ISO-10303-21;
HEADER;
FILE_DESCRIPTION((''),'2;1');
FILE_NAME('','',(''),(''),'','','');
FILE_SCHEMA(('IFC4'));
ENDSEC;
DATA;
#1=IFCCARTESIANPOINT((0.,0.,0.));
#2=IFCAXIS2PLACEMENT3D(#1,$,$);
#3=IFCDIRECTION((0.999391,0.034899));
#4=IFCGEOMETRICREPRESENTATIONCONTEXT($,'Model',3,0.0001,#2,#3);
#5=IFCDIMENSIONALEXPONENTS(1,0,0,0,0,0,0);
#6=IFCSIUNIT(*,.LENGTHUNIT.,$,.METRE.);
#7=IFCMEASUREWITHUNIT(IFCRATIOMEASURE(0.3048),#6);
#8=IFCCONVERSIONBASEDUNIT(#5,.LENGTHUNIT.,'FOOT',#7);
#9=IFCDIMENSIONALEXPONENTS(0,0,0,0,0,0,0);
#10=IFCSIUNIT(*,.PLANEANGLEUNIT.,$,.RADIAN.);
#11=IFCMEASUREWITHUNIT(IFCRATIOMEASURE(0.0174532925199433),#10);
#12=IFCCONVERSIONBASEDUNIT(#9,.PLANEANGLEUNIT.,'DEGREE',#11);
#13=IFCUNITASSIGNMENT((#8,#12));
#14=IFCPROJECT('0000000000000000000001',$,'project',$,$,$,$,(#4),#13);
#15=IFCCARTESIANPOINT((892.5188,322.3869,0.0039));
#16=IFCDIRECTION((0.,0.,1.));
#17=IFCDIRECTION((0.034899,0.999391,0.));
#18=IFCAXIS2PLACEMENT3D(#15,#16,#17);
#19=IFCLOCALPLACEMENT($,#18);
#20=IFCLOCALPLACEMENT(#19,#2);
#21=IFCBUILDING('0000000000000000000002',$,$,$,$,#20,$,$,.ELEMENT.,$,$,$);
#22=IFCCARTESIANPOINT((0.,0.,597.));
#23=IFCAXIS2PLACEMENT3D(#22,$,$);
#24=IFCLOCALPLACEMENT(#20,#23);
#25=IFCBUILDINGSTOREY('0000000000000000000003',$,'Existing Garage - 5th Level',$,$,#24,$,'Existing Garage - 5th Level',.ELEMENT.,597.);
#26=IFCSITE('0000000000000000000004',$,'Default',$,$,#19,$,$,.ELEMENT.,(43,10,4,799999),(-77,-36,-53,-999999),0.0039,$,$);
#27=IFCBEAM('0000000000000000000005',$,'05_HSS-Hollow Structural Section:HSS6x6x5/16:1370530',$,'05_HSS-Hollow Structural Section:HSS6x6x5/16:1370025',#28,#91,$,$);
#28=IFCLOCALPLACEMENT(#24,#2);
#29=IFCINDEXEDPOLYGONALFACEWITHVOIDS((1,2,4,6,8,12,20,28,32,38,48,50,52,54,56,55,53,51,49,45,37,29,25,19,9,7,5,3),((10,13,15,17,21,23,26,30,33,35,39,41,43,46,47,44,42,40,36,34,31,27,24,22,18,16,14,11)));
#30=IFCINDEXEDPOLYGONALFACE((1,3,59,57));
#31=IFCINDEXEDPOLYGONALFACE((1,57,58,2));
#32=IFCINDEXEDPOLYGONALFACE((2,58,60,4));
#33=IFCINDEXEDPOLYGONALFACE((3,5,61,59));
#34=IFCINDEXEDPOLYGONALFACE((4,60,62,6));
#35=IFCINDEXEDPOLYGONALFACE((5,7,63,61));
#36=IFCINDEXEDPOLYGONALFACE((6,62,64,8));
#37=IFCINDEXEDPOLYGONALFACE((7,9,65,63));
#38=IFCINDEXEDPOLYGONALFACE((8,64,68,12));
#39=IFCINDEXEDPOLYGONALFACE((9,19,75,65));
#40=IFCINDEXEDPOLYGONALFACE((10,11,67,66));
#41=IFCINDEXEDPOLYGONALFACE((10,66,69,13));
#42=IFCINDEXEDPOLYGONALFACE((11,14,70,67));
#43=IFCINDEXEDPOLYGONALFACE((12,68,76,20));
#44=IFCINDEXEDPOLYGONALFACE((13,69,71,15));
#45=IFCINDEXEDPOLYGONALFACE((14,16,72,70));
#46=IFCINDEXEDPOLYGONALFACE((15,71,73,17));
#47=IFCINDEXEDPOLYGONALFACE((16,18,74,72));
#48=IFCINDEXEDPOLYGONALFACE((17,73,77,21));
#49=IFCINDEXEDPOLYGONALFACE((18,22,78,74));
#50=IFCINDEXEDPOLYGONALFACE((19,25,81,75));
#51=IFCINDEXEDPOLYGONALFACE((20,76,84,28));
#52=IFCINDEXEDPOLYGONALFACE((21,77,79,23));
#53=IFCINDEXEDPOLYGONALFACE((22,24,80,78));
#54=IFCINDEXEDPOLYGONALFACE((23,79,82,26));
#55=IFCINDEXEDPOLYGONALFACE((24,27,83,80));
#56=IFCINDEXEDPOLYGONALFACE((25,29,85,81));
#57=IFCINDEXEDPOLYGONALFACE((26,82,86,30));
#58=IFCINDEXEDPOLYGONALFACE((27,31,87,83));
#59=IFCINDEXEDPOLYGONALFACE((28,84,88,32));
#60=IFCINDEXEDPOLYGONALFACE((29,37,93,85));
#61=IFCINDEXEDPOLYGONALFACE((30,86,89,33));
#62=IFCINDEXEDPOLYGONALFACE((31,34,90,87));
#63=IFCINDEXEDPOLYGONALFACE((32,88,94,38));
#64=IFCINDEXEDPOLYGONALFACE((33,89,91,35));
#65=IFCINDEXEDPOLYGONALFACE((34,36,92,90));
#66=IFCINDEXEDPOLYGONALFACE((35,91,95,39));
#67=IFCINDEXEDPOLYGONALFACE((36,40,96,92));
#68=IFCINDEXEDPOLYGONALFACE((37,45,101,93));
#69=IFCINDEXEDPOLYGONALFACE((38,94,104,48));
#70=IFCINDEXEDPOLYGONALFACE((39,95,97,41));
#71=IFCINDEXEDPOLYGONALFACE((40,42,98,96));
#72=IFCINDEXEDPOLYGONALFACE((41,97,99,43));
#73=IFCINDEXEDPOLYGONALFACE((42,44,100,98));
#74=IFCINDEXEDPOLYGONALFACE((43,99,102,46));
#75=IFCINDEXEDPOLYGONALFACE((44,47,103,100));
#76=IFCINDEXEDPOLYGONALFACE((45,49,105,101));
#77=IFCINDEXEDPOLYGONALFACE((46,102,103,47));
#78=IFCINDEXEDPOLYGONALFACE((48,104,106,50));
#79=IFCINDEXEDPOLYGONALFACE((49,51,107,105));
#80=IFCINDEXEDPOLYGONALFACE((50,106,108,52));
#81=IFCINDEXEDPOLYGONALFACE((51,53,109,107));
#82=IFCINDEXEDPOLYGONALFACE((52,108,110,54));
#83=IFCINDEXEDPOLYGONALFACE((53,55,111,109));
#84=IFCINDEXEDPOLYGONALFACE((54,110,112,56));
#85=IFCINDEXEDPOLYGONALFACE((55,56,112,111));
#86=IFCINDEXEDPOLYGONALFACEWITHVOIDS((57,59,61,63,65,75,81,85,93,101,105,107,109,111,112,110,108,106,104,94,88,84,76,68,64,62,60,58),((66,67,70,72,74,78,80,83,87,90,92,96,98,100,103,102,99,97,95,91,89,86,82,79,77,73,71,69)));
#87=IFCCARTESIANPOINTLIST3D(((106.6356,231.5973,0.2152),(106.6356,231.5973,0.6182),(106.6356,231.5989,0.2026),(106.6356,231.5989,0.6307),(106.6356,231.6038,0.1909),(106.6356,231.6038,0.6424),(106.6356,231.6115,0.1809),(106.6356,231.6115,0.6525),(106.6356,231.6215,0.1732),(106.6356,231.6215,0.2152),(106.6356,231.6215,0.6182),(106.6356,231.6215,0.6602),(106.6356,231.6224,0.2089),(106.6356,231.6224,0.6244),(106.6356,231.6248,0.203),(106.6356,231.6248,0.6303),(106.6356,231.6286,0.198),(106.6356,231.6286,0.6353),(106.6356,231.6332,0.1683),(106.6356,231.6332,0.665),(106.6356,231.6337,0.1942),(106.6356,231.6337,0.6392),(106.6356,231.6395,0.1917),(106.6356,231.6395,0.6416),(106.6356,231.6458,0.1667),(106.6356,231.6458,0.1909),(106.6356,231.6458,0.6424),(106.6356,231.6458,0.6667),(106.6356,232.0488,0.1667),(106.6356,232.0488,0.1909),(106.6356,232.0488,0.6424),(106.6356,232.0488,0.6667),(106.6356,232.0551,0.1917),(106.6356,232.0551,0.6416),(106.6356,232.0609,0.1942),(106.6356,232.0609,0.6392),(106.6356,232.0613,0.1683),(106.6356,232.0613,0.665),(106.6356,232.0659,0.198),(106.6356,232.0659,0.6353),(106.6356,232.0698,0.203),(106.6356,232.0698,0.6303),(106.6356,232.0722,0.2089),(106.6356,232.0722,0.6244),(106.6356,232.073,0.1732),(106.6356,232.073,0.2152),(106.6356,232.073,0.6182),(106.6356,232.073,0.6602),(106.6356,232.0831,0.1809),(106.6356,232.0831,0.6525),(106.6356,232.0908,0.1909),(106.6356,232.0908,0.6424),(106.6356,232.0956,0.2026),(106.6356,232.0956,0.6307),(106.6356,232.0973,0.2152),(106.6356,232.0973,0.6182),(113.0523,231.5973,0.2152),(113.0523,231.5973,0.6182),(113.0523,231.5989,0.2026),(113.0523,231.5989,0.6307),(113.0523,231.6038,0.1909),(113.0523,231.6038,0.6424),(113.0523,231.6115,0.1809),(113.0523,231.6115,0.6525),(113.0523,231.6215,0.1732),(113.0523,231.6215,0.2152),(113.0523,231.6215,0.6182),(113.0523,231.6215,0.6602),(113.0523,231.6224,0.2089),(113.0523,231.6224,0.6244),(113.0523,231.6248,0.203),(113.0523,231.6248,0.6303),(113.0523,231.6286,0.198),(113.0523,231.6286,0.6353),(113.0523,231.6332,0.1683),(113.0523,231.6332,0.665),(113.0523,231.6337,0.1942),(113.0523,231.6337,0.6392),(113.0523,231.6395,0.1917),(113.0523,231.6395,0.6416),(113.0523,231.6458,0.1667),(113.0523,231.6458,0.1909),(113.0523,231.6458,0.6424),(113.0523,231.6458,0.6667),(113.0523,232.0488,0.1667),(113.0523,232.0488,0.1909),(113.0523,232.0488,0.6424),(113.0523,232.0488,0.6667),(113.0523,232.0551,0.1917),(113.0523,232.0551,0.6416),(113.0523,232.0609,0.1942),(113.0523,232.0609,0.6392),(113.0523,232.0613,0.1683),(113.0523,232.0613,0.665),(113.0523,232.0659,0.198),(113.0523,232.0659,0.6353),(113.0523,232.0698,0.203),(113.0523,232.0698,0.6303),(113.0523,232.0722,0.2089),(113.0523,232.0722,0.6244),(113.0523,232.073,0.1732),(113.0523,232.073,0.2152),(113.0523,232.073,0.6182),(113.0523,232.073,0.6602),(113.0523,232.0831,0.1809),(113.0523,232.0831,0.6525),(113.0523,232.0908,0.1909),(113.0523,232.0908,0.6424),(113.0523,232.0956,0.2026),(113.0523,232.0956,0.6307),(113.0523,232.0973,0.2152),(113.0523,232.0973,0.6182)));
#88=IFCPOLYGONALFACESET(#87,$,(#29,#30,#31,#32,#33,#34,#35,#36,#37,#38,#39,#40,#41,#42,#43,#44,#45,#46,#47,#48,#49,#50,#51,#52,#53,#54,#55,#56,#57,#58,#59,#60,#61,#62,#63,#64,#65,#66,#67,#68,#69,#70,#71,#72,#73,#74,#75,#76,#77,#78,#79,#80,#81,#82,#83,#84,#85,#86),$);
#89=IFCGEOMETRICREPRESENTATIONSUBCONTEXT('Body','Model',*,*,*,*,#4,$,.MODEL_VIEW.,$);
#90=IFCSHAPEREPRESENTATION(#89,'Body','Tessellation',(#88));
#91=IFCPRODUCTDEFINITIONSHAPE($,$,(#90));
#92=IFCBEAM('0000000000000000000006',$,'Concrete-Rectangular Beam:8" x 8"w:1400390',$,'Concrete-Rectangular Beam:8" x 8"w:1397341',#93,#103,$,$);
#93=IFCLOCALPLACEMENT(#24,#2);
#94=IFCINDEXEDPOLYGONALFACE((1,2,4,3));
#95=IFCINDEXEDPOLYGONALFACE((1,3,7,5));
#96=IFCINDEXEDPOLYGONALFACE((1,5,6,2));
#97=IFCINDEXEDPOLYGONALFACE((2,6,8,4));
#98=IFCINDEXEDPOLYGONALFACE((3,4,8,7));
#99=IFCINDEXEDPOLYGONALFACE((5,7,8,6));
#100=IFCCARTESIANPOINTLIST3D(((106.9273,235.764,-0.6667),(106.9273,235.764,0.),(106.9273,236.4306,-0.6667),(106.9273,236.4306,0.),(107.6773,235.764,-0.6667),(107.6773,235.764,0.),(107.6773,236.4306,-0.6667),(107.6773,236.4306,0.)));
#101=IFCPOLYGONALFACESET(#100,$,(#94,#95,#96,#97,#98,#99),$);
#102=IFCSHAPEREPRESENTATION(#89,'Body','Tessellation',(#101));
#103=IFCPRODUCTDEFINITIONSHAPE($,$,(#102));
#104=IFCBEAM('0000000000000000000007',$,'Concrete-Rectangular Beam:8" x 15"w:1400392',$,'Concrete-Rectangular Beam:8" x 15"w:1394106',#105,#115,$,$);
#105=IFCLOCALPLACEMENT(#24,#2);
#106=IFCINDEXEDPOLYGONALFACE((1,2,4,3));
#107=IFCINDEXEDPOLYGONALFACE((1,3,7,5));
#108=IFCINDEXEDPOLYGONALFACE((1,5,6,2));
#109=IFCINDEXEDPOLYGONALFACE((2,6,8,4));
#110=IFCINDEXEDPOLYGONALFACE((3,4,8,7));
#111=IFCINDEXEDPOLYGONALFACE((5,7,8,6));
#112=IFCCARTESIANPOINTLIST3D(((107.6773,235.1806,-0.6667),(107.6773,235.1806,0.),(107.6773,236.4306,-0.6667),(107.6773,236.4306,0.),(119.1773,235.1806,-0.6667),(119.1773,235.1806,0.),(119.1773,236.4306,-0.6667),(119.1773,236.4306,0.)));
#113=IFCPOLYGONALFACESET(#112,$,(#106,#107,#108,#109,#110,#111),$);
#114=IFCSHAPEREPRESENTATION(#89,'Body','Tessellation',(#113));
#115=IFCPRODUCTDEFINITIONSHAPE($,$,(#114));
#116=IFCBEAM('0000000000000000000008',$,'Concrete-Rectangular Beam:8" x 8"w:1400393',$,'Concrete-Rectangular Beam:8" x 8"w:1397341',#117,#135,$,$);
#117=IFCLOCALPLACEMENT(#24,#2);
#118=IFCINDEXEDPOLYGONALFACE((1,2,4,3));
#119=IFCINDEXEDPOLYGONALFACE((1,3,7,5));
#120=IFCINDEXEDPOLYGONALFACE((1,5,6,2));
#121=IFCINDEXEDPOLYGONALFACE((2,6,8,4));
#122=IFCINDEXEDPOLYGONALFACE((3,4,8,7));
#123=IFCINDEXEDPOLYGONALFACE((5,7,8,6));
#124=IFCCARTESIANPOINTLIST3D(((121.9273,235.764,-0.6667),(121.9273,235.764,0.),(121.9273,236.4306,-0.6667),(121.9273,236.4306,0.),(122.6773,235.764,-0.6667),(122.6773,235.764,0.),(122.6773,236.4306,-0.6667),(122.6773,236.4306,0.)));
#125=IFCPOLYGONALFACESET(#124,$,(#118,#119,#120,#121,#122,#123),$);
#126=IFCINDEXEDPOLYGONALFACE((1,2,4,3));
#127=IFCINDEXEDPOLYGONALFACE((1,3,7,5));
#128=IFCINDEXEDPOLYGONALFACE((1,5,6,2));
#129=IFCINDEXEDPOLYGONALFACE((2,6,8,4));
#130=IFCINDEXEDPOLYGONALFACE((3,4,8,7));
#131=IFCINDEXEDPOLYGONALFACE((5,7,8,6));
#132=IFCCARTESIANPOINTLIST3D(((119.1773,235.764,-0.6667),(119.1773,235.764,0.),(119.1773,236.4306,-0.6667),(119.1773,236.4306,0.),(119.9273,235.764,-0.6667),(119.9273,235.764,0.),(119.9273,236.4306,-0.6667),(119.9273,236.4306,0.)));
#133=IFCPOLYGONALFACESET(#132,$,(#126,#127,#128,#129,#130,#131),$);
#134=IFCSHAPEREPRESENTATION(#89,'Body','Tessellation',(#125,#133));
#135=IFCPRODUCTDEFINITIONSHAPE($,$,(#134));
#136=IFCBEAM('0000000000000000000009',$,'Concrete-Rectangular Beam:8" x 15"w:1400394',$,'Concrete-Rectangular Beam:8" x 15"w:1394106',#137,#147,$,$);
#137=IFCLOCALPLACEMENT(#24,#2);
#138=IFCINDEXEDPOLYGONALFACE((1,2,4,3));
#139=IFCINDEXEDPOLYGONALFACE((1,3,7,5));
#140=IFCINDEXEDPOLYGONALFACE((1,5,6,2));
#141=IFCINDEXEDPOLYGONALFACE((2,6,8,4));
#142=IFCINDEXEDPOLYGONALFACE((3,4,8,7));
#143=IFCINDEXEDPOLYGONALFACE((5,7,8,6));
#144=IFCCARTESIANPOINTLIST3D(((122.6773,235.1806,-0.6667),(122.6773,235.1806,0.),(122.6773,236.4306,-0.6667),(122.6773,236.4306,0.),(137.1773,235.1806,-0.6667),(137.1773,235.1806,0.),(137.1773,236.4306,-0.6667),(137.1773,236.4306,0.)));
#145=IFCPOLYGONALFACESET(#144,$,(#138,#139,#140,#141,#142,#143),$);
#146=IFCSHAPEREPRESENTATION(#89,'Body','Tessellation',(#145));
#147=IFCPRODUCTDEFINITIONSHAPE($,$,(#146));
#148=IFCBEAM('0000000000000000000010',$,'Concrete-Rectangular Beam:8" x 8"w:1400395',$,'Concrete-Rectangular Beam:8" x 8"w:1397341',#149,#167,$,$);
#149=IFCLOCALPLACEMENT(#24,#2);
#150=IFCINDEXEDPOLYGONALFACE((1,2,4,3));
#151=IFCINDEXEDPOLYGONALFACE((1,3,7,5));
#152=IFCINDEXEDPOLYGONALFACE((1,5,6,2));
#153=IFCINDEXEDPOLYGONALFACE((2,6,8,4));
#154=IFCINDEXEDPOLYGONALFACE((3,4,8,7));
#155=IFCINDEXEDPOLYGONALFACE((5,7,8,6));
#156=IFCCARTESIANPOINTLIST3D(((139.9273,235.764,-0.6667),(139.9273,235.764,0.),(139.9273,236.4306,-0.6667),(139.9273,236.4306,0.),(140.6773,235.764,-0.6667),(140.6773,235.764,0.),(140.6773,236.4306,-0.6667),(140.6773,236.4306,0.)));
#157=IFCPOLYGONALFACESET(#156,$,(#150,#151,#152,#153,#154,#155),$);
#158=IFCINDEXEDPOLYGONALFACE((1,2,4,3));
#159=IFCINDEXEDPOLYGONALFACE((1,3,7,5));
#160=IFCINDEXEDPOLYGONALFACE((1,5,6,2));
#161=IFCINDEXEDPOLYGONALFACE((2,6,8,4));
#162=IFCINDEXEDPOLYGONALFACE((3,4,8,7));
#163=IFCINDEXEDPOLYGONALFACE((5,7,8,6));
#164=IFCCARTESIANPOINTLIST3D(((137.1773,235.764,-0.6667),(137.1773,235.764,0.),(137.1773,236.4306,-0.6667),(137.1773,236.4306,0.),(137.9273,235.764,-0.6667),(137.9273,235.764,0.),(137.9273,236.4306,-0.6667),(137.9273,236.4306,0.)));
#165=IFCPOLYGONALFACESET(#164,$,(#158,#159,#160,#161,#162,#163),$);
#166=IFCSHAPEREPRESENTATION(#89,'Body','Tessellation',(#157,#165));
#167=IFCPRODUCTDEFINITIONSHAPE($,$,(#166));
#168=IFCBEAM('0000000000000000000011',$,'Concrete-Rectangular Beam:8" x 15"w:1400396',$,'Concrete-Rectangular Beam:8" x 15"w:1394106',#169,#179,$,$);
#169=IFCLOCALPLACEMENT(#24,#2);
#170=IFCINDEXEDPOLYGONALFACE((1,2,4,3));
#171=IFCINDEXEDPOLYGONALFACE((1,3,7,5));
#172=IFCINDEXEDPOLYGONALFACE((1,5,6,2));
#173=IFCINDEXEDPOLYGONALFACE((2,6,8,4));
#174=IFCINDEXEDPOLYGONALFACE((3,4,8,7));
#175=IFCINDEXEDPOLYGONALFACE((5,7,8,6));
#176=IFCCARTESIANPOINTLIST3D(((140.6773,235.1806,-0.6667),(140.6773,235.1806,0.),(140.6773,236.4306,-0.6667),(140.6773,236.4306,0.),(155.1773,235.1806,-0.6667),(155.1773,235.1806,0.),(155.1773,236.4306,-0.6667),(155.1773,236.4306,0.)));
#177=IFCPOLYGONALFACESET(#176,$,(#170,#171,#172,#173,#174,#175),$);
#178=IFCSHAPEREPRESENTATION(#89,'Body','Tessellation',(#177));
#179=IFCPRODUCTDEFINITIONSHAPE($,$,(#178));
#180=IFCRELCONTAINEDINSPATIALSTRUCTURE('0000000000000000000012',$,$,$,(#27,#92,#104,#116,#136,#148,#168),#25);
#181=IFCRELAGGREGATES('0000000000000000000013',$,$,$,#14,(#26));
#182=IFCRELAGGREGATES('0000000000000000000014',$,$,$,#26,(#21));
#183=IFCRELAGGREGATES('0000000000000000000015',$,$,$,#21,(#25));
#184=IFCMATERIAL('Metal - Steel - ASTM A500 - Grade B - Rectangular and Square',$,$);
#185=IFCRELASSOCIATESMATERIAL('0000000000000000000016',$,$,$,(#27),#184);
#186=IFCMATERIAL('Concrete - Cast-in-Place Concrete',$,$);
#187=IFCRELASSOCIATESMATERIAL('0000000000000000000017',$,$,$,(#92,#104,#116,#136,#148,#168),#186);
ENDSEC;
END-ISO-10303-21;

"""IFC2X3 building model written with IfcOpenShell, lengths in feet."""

from ifc_helpers import new_model, entity, si_unit, converted_unit, direction, frame, frame_2d, origin, origin_2d_with_axis, place, context, subcontext, project, spatial, polyline, circle_curve, parameter, trimmed, segment, composite_curve, rectangle, outline, extrude, material, element, save


model = new_model("IFC2X3")

# Units and contexts
model_context = context("Model", 3, precision=0.0001, world=origin(), true_north=direction((0.999391, 0.034899)))
body_context = subcontext(model_context, "Body", "Model", "MODEL_VIEW")
ifc_project = project(units=[converted_unit("LENGTHUNIT", "FOOT", entity("IfcRatioMeasure", 0.3048), si_unit("LENGTHUNIT", "METRE"), dimensions=[1, 0, 0, 0, 0, 0, 0]), converted_unit("PLANEANGLEUNIT", "DEGREE", entity("IfcRatioMeasure", 0.0174532925199433), si_unit("PLANEANGLEUNIT", "RADIAN"), dimensions=[0, 0, 0, 0, 0, 0, 0])], contexts=[model_context])

# Site, building, storey
site_placement = place(None, frame((892.5188, 322.3869, 0.0039), z_axis=(0.0, 0.0, 1.0), x_axis=(0.034899, 0.999391, 0.0)))
site = spatial("IfcSite", under=ifc_project, at=site_placement, Name="Default", CompositionType="ELEMENT", RefLatitude=(43, 10, 4, 799999), RefLongitude=(-77, -36, -53, -999999), RefElevation=0.0039)
building_placement = place(site_placement, origin())
building = spatial("IfcBuilding", under=site, at=building_placement, CompositionType="ELEMENT")
storey_placement = place(building_placement, frame((0.0, 0.0, 597.0)))
storey = spatial("IfcBuildingStorey", under=building, at=storey_placement, Name="Existing Garage - 5th Level", LongName="Existing Garage - 5th Level", CompositionType="ELEMENT", Elevation=597.0)

# Beams
ifc_material_1 = material(Name="Metal - Steel - ASTM A500 - Grade B - Rectangular and Square")
beam_1_placement = place(storey_placement, frame((113.344, 231.8473, 0.6667), z_axis=(0.0, 0.0, 1.0), x_axis=(-1.0, 0.0, 0.0)))
element("IfcBeam", 1, at=beam_1_placement, inside=storey, material=ifc_material_1, Name="05_HSS-Hollow Structural Section:HSS6x6x5/16:1370530", ObjectType="05_HSS-Hollow Structural Section:HSS6x6x5/16:1370025", context=body_context, shape_type="SweptSolid", body=[
    extrude(outline(composite_curve([segment(trimmed(circle_curve(frame_2d((-0.2015, -0.2015), x_axis=(1.0, 0.0)), 0.0485), [parameter(180.0)], [parameter(270.0)], True, "PARAMETER"), True, "CONTINUOUS"), segment(polyline([(-0.2015, -0.25), (0.2015, -0.25)]), True, "CONTINUOUS"), segment(trimmed(circle_curve(frame_2d((0.2015, -0.2015), x_axis=(1.0, 0.0)), 0.0485), [parameter(270.0)], [parameter(0.0)], True, "PARAMETER"), True, "CONTINUOUS"), segment(polyline([(0.25, -0.2015), (0.25, 0.2015)]), True, "CONTINUOUS"), segment(trimmed(circle_curve(frame_2d((0.2015, 0.2015), x_axis=(1.0, 0.0)), 0.0485), [parameter(360.0)], [parameter(90.0)], True, "PARAMETER"), True, "CONTINUOUS"), segment(polyline([(0.2015, 0.25), (-0.2015, 0.25)]), True, "CONTINUOUS"), segment(trimmed(circle_curve(frame_2d((-0.2015, 0.2015), x_axis=(1.0, 0.0)), 0.0485), [parameter(90.0)], [parameter(180.0)], True, "PARAMETER"), True, "CONTINUOUS"), segment(polyline([(-0.25, 0.2015), (-0.25, -0.2015)]), True, "CONTINUOUS")], self_intersect=False), holes=[composite_curve([segment(polyline([(0.2015, -0.2257), (-0.2015, -0.2257)]), True, "CONTINUOUS"), segment(trimmed(circle_curve(frame_2d((-0.2015, -0.2015), x_axis=(1.0, 0.0)), 0.0243), [parameter(180.0)], [parameter(270.0)], True, "PARAMETER"), False, "CONTINUOUS"), segment(polyline([(-0.2258, -0.2015), (-0.2258, 0.2015)]), True, "CONTINUOUS"), segment(trimmed(circle_curve(frame_2d((-0.2015, 0.2015), x_axis=(1.0, 0.0)), 0.0243), [parameter(90.0)], [parameter(180.0)], True, "PARAMETER"), False, "CONTINUOUS"), segment(polyline([(-0.2015, 0.2258), (0.2015, 0.2258)]), True, "CONTINUOUS"), segment(trimmed(circle_curve(frame_2d((0.2015, 0.2015), x_axis=(1.0, 0.0)), 0.0243), [parameter(0.0)], [parameter(90.0)], True, "PARAMETER"), False, "CONTINUOUS"), segment(polyline([(0.2257, 0.2015), (0.2257, -0.2015)]), True, "CONTINUOUS"), segment(trimmed(circle_curve(frame_2d((0.2015, -0.2015), x_axis=(1.0, 0.0)), 0.0243), [parameter(270.0)], [parameter(0.0)], True, "PARAMETER"), False, "CONTINUOUS")], self_intersect=False)]), frame((0.2917, 0.0, -0.25), z_axis=(1.0, 0.0, 0.0), x_axis=(0.0, -1.0, 0.0)), (0.0, 0.0, 1.0), 6.4167),
])
ifc_material_2 = material(Name="Concrete - Cast-in-Place Concrete")
beam_2_placement = place(storey_placement, frame((105.9273, 236.0973, 0.0)))
element("IfcBeam", 2, at=beam_2_placement, inside=storey, material=ifc_material_2, Name="Concrete-Rectangular Beam:8\" x 8\"w:1400390", ObjectType="Concrete-Rectangular Beam:8\" x 8\"w:1397341", context=body_context, shape_type="SweptSolid", body=[
    extrude(rectangle(XDim=0.6667, YDim=0.6667, at=origin_2d_with_axis()), frame((1.0, 0.0, -0.3333), z_axis=(1.0, 0.0, 0.0), x_axis=(0.0, 0.0, -1.0)), (0.0, 0.0, 1.0), 0.75),
])
beam_3_placement = place(storey_placement, frame((107.6773, 235.8056, 0.0)))
element("IfcBeam", 3, at=beam_3_placement, inside=storey, material=ifc_material_2, Name="Concrete-Rectangular Beam:8\" x 15\"w:1400392", ObjectType="Concrete-Rectangular Beam:8\" x 15\"w:1394106", context=body_context, shape_type="SweptSolid", body=[
    extrude(rectangle(XDim=0.6667, YDim=1.25, at=frame_2d((0.0, 0.0), x_axis=(1.0, 0.0))), frame((0.0, 0.0, -0.3333), z_axis=(1.0, 0.0, 0.0), x_axis=(0.0, 0.0, -1.0)), (0.0, 0.0, 1.0), 11.5),
])
beam_4_placement = place(storey_placement, frame((119.1773, 236.0973, 0.0)))
element("IfcBeam", 4, at=beam_4_placement, inside=storey, material=ifc_material_2, Name="Concrete-Rectangular Beam:8\" x 8\"w:1400393", ObjectType="Concrete-Rectangular Beam:8\" x 8\"w:1397341", context=body_context, shape_type="SweptSolid", body=[
    extrude(rectangle(XDim=0.6667, YDim=0.6667, at=frame_2d((0.0, 0.0), x_axis=(1.0, 0.0))), frame((2.75, 0.0, -0.3333), z_axis=(1.0, 0.0, 0.0), x_axis=(0.0, 0.0, -1.0)), (0.0, 0.0, 1.0), 0.75),
    extrude(rectangle(XDim=0.6667, YDim=0.6667, at=frame_2d((0.0, 0.0), x_axis=(0.0, 1.0))), frame((0.0, 0.0, -0.3333), z_axis=(1.0, 0.0, 0.0), x_axis=(0.0, -1.0, 0.0)), (0.0, 0.0, 1.0), 0.75),
])
beam_5_placement = place(storey_placement, frame((122.6773, 235.8056, 0.0)))
element("IfcBeam", 5, at=beam_5_placement, inside=storey, material=ifc_material_2, Name="Concrete-Rectangular Beam:8\" x 15\"w:1400394", ObjectType="Concrete-Rectangular Beam:8\" x 15\"w:1394106", context=body_context, shape_type="SweptSolid", body=[
    extrude(rectangle(XDim=0.6667, YDim=1.25, at=frame_2d((0.0, 0.0), x_axis=(1.0, 0.0))), frame((0.0, 0.0, -0.3333), z_axis=(1.0, 0.0, 0.0), x_axis=(0.0, 0.0, -1.0)), (0.0, 0.0, 1.0), 14.5),
])
beam_6_placement = place(storey_placement, frame((137.1773, 236.0973, 0.0)))
element("IfcBeam", 6, at=beam_6_placement, inside=storey, material=ifc_material_2, Name="Concrete-Rectangular Beam:8\" x 8\"w:1400395", ObjectType="Concrete-Rectangular Beam:8\" x 8\"w:1397341", context=body_context, shape_type="SweptSolid", body=[
    extrude(rectangle(XDim=0.6667, YDim=0.6667, at=frame_2d((0.0, 0.0), x_axis=(1.0, 0.0))), frame((2.75, 0.0, -0.3333), z_axis=(1.0, 0.0, 0.0), x_axis=(0.0, 0.0, -1.0)), (0.0, 0.0, 1.0), 0.75),
    extrude(rectangle(XDim=0.6667, YDim=0.6667, at=frame_2d((0.0, 0.0), x_axis=(0.0, 1.0))), frame((0.0, 0.0, -0.3333), z_axis=(1.0, 0.0, 0.0), x_axis=(0.0, -1.0, 0.0)), (0.0, 0.0, 1.0), 0.75),
])
beam_7_placement = place(storey_placement, frame((140.6773, 235.8056, 0.0)))
element("IfcBeam", 7, at=beam_7_placement, inside=storey, material=ifc_material_2, Name="Concrete-Rectangular Beam:8\" x 15\"w:1400396", ObjectType="Concrete-Rectangular Beam:8\" x 15\"w:1394106", context=body_context, shape_type="SweptSolid", body=[
    extrude(rectangle(XDim=0.6667, YDim=1.25, at=frame_2d((0.0, 0.0), x_axis=(1.0, 0.0))), frame((0.0, 0.0, -0.3333), z_axis=(1.0, 0.0, 0.0), x_axis=(0.0, 0.0, -1.0)), (0.0, 0.0, 1.0), 14.5),
])

save(model, "model.ifc")
